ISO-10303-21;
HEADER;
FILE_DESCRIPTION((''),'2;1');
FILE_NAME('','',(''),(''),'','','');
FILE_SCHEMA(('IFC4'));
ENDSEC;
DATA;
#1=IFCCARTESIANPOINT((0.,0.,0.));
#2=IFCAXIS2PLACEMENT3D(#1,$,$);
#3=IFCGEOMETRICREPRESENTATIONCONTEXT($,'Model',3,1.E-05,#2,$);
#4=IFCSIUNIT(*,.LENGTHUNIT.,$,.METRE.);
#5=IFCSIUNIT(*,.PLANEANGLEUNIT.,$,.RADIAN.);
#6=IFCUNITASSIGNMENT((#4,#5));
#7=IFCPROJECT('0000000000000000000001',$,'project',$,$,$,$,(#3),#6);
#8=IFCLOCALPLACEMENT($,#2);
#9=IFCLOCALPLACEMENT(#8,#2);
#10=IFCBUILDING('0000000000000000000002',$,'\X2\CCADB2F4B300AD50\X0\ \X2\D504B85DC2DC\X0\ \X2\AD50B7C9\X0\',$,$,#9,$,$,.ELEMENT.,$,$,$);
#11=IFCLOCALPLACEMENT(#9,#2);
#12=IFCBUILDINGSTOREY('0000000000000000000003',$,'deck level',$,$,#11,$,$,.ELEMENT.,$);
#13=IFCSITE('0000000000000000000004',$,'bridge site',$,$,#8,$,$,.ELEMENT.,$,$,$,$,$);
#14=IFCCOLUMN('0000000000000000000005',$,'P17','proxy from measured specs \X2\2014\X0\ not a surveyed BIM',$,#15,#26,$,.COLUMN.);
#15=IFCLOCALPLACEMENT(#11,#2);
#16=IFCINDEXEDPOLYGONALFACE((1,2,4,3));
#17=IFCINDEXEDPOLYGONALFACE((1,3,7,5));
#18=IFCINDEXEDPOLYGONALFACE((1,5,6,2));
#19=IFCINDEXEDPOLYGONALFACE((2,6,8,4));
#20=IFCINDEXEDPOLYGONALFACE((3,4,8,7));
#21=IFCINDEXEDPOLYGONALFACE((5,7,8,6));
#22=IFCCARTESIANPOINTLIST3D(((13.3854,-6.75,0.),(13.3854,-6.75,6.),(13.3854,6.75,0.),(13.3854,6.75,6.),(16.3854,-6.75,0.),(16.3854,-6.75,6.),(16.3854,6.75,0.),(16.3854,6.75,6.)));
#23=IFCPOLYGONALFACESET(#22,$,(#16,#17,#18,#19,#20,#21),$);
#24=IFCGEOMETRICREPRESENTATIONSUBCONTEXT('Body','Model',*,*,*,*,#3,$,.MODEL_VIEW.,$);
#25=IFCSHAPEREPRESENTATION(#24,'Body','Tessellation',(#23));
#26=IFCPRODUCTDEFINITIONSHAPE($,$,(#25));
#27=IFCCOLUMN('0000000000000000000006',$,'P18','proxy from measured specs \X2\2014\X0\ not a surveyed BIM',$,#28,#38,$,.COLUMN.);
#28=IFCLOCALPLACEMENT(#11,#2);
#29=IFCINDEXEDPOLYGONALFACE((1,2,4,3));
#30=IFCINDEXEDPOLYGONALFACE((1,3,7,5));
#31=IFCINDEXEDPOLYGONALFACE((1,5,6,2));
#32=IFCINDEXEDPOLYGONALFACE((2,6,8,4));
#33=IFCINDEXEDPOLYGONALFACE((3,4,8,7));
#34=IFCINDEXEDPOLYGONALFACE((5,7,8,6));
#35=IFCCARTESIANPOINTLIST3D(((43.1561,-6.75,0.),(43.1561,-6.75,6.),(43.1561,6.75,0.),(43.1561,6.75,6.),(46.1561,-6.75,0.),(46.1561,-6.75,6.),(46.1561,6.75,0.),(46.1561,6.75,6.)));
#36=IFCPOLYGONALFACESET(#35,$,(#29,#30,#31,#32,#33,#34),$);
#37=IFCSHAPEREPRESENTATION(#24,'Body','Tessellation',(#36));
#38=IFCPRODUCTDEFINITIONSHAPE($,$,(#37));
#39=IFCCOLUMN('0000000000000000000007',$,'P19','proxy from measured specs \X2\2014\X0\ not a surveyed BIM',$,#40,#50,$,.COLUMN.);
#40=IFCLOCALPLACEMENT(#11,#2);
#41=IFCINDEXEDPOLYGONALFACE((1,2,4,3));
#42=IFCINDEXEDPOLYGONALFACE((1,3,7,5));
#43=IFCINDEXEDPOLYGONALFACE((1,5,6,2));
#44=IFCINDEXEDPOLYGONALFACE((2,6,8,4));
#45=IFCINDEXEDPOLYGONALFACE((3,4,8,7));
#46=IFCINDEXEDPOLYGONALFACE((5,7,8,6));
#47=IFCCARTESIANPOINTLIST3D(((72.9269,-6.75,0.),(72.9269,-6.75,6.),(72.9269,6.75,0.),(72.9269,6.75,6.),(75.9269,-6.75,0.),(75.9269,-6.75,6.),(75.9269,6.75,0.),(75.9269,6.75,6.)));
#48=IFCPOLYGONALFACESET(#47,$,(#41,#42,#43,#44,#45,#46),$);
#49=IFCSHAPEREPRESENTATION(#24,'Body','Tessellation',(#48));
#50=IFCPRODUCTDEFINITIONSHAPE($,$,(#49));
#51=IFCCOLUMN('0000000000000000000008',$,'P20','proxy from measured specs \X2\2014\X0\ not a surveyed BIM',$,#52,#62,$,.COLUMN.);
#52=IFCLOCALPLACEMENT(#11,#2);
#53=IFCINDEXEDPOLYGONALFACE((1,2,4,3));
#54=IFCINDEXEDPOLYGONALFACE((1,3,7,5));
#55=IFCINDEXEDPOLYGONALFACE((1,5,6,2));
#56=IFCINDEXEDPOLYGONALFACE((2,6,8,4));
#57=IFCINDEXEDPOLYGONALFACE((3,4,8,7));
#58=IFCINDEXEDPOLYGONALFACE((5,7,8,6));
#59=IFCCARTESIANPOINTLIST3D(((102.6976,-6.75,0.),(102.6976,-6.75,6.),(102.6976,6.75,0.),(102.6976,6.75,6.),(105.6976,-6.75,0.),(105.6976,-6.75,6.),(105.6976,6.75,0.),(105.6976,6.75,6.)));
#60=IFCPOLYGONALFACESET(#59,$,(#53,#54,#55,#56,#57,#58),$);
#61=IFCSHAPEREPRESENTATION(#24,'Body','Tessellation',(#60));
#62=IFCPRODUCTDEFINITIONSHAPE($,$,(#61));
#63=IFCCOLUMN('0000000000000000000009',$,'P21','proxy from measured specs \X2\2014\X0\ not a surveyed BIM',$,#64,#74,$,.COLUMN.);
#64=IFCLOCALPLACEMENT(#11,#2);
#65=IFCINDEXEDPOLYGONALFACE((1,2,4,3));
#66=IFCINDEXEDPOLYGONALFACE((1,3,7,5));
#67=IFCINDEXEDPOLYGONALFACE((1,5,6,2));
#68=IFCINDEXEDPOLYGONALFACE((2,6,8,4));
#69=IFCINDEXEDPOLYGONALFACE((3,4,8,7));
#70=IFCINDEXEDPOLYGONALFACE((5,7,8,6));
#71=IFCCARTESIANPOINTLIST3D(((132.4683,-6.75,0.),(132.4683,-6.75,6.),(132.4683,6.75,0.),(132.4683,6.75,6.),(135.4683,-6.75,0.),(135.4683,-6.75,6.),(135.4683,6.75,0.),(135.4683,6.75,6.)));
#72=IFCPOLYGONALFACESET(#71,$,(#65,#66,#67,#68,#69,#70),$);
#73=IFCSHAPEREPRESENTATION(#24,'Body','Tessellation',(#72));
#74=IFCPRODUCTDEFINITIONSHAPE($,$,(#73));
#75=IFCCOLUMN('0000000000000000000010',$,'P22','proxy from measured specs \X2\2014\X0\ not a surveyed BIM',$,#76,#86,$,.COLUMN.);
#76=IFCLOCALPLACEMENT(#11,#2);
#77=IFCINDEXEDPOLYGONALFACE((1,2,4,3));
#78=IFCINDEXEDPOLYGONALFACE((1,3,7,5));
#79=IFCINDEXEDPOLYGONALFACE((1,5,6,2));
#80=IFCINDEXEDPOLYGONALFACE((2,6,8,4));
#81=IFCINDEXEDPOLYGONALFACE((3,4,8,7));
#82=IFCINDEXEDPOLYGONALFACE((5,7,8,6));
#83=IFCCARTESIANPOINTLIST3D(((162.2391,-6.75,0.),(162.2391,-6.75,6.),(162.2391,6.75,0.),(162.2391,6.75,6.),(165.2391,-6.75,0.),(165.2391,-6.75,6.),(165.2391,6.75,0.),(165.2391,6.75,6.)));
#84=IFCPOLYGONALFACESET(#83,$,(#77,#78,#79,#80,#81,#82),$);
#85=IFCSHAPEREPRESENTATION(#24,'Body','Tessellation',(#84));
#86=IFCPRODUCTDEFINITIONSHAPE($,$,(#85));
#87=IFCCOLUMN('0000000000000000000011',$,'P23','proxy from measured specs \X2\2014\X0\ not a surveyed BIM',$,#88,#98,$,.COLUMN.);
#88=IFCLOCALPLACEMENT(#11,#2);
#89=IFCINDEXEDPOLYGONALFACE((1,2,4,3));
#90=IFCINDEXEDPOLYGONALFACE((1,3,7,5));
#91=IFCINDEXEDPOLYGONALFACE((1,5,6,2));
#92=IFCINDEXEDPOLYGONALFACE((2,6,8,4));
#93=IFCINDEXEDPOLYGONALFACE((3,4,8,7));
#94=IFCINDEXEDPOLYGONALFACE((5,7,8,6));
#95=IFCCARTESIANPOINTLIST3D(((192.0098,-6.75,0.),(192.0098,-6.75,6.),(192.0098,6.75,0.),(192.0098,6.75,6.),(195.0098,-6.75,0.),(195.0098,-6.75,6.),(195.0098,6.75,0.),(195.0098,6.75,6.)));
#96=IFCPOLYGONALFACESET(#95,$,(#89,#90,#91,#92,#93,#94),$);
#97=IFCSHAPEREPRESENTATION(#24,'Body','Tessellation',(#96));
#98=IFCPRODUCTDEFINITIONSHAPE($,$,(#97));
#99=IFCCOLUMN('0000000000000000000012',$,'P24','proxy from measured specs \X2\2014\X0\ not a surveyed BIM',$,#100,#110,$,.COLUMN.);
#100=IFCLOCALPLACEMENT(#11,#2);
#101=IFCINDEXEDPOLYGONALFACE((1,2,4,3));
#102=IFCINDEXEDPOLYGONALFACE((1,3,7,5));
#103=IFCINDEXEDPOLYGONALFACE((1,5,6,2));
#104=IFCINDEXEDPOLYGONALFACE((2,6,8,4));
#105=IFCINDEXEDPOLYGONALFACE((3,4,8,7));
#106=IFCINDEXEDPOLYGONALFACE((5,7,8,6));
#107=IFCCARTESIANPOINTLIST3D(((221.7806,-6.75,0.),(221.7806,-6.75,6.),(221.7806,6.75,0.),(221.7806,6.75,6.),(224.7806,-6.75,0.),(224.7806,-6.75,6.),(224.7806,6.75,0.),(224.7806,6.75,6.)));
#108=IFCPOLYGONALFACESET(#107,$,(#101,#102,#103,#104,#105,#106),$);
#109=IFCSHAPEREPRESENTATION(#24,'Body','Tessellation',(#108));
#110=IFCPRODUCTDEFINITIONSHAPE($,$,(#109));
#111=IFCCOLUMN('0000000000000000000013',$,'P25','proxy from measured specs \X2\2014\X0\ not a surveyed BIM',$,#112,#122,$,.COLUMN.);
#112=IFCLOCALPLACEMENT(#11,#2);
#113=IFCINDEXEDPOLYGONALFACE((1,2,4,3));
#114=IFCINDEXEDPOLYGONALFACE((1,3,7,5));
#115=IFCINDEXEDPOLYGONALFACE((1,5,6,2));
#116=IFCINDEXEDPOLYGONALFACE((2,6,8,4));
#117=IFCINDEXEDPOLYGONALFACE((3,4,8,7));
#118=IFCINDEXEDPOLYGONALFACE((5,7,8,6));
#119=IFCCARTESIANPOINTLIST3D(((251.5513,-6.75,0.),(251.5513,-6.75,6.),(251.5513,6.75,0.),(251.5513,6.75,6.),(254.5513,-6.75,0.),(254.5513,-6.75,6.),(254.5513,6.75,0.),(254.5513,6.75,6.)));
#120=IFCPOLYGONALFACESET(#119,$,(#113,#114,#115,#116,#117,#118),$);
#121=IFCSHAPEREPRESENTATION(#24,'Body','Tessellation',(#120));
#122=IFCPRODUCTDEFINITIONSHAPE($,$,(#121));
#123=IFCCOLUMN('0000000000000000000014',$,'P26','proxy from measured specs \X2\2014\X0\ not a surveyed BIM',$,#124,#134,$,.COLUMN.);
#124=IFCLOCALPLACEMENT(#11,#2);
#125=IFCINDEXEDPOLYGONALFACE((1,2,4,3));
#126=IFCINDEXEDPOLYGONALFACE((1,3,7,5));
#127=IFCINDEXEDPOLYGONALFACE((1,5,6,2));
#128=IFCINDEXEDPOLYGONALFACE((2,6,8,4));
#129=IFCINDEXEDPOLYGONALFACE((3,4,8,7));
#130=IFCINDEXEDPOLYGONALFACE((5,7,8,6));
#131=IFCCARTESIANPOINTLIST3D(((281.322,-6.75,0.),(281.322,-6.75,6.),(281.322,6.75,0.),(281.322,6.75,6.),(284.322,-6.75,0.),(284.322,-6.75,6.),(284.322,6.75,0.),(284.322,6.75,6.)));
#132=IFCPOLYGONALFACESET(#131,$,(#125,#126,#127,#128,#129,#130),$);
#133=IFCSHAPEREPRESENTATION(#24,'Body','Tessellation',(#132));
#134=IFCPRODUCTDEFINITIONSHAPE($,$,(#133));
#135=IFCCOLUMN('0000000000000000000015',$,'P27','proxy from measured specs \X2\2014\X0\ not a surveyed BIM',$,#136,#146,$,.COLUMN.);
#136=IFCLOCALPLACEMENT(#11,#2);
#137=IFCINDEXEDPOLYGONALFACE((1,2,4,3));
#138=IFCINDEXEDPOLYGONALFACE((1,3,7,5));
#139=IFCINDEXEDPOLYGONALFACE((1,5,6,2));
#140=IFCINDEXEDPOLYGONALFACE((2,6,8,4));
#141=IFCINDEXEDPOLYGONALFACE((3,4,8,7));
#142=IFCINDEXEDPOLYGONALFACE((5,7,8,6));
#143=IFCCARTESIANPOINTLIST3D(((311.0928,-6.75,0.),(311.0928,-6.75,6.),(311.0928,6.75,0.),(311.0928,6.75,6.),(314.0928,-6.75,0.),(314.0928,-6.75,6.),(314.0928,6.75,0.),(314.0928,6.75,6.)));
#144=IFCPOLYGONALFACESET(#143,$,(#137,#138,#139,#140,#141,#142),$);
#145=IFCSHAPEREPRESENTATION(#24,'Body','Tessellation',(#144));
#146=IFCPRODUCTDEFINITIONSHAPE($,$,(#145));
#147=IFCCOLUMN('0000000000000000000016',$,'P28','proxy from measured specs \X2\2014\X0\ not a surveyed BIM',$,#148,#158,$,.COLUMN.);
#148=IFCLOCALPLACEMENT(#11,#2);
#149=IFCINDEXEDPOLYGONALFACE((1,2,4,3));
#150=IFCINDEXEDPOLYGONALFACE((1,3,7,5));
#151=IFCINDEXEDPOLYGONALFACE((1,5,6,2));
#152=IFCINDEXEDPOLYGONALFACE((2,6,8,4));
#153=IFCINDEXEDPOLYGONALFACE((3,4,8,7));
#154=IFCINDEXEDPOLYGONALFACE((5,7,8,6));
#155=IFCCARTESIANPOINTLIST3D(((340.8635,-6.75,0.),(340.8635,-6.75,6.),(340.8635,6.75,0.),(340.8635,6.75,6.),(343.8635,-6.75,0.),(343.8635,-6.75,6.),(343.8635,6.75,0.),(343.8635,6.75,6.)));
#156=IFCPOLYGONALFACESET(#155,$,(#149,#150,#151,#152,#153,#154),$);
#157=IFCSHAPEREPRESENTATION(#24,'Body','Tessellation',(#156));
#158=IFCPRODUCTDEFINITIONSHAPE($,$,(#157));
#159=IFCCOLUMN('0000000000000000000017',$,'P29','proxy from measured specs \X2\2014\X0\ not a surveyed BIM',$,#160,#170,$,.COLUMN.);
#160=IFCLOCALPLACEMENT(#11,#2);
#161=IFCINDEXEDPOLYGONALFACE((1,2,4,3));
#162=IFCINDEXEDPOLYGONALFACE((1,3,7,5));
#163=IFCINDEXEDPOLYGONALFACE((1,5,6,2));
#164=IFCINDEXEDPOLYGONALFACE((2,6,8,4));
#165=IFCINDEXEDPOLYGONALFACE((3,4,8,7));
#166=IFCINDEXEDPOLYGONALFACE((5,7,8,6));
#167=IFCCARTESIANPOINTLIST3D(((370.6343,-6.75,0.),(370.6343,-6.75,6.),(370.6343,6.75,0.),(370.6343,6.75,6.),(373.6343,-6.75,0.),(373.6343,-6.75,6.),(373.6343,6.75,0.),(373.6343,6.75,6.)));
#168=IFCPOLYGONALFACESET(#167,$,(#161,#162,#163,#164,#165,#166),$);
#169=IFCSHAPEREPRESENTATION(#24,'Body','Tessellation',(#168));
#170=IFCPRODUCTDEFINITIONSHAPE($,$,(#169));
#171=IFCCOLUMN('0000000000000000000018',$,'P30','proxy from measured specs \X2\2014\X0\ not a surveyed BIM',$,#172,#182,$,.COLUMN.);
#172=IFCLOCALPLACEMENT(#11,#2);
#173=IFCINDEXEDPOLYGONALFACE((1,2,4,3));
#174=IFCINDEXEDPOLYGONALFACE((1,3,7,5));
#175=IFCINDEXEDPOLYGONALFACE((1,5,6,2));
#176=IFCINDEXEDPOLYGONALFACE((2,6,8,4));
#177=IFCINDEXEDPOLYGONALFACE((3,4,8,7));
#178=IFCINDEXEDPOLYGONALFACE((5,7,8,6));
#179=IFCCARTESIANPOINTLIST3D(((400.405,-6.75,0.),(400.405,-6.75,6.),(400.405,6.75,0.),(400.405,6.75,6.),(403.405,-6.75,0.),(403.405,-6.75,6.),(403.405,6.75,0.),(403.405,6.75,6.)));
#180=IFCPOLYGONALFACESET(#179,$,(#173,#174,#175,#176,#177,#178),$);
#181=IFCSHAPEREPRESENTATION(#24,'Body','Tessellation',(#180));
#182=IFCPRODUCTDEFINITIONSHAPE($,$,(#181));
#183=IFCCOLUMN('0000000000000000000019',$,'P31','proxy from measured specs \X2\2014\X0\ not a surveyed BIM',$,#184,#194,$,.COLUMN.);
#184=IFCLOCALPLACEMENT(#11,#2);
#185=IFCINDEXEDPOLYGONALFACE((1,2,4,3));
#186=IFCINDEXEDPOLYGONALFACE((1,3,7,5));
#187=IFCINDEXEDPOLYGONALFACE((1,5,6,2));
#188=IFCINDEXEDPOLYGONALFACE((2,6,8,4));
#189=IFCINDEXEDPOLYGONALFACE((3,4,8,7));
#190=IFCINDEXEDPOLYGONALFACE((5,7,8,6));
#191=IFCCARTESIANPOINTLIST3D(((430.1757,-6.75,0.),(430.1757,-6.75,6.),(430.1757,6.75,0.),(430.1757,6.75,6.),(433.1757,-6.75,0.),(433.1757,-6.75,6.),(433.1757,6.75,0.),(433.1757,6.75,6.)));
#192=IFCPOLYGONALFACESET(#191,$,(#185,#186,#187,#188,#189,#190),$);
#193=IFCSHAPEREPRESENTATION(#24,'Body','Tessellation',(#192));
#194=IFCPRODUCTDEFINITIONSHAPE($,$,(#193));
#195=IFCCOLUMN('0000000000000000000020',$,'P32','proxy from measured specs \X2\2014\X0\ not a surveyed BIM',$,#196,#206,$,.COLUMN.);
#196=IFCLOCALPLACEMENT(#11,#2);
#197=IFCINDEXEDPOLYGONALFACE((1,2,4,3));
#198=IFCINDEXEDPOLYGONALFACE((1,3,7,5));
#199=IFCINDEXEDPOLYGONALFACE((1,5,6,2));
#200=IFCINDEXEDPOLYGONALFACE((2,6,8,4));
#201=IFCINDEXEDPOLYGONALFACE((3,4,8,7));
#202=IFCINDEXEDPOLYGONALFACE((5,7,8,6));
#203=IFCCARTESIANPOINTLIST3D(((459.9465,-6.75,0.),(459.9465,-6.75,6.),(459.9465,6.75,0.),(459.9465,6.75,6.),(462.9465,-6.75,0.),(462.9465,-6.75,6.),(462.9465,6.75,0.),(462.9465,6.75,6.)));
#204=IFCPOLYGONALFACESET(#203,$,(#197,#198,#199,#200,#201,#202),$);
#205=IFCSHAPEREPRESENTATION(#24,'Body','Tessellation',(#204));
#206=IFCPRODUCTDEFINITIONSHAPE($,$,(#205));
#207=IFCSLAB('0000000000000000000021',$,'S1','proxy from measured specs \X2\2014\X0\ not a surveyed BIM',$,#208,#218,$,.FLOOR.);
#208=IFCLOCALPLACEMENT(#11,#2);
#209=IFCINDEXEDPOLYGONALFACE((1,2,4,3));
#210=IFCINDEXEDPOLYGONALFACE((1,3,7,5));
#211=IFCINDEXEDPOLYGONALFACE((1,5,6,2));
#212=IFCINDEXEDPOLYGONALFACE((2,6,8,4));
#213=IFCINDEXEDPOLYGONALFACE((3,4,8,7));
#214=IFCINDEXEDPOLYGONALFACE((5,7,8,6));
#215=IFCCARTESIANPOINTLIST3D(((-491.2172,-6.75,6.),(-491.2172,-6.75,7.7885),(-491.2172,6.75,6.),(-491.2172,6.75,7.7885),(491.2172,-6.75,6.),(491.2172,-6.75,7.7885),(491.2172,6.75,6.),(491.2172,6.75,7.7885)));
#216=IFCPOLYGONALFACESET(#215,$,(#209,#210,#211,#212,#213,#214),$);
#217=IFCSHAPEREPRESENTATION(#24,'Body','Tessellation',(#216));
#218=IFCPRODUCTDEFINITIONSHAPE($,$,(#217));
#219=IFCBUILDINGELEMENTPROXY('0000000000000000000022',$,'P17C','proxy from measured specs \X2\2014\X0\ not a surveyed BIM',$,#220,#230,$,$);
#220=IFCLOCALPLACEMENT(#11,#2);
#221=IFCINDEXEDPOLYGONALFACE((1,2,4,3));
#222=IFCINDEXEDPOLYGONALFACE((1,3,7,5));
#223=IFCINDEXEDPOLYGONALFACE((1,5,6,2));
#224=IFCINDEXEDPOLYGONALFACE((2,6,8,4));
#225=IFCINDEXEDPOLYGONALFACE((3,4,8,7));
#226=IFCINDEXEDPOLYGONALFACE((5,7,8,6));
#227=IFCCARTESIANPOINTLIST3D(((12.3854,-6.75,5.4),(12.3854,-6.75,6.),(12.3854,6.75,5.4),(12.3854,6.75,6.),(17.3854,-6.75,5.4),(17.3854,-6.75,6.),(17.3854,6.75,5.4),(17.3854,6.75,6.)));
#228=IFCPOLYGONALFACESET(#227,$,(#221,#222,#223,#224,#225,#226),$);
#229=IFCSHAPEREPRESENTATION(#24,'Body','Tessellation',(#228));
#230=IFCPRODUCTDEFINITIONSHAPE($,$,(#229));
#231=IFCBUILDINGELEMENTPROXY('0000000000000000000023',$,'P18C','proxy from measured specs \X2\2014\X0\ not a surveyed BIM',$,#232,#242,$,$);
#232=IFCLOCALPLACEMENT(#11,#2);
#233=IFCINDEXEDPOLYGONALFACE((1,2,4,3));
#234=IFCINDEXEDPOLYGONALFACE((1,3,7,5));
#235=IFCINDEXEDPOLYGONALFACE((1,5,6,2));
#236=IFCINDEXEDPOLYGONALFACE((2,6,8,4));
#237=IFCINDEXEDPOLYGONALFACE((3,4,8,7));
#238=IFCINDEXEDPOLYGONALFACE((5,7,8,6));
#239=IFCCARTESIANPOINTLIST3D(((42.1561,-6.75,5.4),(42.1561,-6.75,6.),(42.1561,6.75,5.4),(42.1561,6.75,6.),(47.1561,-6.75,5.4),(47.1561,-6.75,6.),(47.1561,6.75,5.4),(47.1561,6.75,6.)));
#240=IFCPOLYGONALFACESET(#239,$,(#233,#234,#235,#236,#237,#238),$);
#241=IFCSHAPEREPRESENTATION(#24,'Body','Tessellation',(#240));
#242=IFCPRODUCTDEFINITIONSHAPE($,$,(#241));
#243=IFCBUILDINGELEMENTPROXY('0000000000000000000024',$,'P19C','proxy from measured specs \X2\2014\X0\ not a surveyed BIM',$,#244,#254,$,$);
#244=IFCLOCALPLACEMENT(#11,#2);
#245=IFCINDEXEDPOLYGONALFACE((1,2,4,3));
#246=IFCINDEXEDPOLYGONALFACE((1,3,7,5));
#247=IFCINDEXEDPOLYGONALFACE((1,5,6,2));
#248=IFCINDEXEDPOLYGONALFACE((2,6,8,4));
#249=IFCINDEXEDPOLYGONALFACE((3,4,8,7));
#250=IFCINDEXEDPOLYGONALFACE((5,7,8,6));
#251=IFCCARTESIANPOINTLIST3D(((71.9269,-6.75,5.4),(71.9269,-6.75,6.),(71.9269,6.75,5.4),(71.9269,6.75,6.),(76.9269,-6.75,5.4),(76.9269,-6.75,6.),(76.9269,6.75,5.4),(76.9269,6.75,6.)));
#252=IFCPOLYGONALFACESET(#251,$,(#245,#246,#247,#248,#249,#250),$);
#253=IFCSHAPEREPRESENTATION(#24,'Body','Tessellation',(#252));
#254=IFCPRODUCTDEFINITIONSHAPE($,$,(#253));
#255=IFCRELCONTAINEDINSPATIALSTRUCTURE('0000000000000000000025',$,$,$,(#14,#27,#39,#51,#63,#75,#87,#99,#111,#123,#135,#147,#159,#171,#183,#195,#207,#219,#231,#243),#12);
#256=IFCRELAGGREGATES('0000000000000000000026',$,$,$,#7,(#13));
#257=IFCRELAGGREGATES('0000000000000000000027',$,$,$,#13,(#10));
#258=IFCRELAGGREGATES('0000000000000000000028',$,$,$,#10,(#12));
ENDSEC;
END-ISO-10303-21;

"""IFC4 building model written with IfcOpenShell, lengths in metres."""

from ifc_helpers import new_model, si_unit, frame, origin, origin_2d, place, context, subcontext, project, spatial, rectangle, extrude, element, save


model = new_model("IFC4")

# Units and contexts
model_context = context("Model", 3, precision=1e-05, world=origin())
body_context = subcontext(model_context, "Body", "Model", "MODEL_VIEW")
ifc_project = project(units=[si_unit("LENGTHUNIT", "METRE"), si_unit("PLANEANGLEUNIT", "RADIAN")], contexts=[model_context])

# Site, building, storey
site_placement = place(None, origin())
site = spatial("IfcSite", under=ifc_project, at=site_placement, Name="bridge site", CompositionType="ELEMENT")
building_placement = place(site_placement, origin())
building = spatial("IfcBuilding", under=site, at=building_placement, Name="청담대교 프록시 교량", CompositionType="ELEMENT")
storey_placement = place(building_placement, origin())
storey = spatial("IfcBuildingStorey", under=building, at=storey_placement, Name="deck level", CompositionType="ELEMENT")

# Columns
for number, where, name in (
    (1, (14.8854, 0.0, 0.0), "P17"),
    (2, (44.6561, 0.0, 0.0), "P18"),
    (3, (74.4269, 0.0, 0.0), "P19"),
    (4, (104.1976, 0.0, 0.0), "P20"),
    (5, (133.9683, 0.0, 0.0), "P21"),
    (6, (163.7391, 0.0, 0.0), "P22"),
    (7, (193.5098, 0.0, 0.0), "P23"),
    (8, (223.2806, 0.0, 0.0), "P24"),
    (9, (253.0513, 0.0, 0.0), "P25"),
    (10, (282.822, 0.0, 0.0), "P26"),
    (11, (312.5928, 0.0, 0.0), "P27"),
    (12, (342.3635, 0.0, 0.0), "P28"),
    (13, (372.1343, 0.0, 0.0), "P29"),
    (14, (401.905, 0.0, 0.0), "P30"),
    (15, (431.6757, 0.0, 0.0), "P31"),
    (16, (461.4465, 0.0, 0.0), "P32"),
):
    element("IfcColumn", number, at=place(storey_placement, frame(where)), inside=storey, Name=name, Description="proxy from measured specs — not a surveyed BIM", PredefinedType="COLUMN", context=body_context, shape_type="SweptSolid", body=[
        extrude(rectangle(XDim=3.0, YDim=13.5, at=origin_2d()), origin(), (0.0, 0.0, 1.0), 6.0),
    ])

# Slab
slab_placement = place(storey_placement, frame((0.0, 0.0, 6.0)))
element("IfcSlab", 17, at=slab_placement, inside=storey, Name="S1", Description="proxy from measured specs — not a surveyed BIM", PredefinedType="FLOOR", context=body_context, shape_type="SweptSolid", body=[
    extrude(rectangle(XDim=982.4344, YDim=13.5, at=origin_2d()), origin(), (0.0, 0.0, 1.0), 1.7885),
])

# Building element proxies
for number, where, name in (
    (18, (14.8854, 0.0, 5.4), "P17C"),
    (19, (44.6561, 0.0, 5.4), "P18C"),
    (20, (74.4269, 0.0, 5.4), "P19C"),
):
    element("IfcBuildingElementProxy", number, at=place(storey_placement, frame(where)), inside=storey, Name=name, Description="proxy from measured specs — not a surveyed BIM", context=body_context, shape_type="SweptSolid", body=[
        extrude(rectangle(XDim=5.0, YDim=13.5, at=origin_2d()), origin(), (0.0, 0.0, 1.0), 0.6),
    ])

save(model, "model.ifc")
